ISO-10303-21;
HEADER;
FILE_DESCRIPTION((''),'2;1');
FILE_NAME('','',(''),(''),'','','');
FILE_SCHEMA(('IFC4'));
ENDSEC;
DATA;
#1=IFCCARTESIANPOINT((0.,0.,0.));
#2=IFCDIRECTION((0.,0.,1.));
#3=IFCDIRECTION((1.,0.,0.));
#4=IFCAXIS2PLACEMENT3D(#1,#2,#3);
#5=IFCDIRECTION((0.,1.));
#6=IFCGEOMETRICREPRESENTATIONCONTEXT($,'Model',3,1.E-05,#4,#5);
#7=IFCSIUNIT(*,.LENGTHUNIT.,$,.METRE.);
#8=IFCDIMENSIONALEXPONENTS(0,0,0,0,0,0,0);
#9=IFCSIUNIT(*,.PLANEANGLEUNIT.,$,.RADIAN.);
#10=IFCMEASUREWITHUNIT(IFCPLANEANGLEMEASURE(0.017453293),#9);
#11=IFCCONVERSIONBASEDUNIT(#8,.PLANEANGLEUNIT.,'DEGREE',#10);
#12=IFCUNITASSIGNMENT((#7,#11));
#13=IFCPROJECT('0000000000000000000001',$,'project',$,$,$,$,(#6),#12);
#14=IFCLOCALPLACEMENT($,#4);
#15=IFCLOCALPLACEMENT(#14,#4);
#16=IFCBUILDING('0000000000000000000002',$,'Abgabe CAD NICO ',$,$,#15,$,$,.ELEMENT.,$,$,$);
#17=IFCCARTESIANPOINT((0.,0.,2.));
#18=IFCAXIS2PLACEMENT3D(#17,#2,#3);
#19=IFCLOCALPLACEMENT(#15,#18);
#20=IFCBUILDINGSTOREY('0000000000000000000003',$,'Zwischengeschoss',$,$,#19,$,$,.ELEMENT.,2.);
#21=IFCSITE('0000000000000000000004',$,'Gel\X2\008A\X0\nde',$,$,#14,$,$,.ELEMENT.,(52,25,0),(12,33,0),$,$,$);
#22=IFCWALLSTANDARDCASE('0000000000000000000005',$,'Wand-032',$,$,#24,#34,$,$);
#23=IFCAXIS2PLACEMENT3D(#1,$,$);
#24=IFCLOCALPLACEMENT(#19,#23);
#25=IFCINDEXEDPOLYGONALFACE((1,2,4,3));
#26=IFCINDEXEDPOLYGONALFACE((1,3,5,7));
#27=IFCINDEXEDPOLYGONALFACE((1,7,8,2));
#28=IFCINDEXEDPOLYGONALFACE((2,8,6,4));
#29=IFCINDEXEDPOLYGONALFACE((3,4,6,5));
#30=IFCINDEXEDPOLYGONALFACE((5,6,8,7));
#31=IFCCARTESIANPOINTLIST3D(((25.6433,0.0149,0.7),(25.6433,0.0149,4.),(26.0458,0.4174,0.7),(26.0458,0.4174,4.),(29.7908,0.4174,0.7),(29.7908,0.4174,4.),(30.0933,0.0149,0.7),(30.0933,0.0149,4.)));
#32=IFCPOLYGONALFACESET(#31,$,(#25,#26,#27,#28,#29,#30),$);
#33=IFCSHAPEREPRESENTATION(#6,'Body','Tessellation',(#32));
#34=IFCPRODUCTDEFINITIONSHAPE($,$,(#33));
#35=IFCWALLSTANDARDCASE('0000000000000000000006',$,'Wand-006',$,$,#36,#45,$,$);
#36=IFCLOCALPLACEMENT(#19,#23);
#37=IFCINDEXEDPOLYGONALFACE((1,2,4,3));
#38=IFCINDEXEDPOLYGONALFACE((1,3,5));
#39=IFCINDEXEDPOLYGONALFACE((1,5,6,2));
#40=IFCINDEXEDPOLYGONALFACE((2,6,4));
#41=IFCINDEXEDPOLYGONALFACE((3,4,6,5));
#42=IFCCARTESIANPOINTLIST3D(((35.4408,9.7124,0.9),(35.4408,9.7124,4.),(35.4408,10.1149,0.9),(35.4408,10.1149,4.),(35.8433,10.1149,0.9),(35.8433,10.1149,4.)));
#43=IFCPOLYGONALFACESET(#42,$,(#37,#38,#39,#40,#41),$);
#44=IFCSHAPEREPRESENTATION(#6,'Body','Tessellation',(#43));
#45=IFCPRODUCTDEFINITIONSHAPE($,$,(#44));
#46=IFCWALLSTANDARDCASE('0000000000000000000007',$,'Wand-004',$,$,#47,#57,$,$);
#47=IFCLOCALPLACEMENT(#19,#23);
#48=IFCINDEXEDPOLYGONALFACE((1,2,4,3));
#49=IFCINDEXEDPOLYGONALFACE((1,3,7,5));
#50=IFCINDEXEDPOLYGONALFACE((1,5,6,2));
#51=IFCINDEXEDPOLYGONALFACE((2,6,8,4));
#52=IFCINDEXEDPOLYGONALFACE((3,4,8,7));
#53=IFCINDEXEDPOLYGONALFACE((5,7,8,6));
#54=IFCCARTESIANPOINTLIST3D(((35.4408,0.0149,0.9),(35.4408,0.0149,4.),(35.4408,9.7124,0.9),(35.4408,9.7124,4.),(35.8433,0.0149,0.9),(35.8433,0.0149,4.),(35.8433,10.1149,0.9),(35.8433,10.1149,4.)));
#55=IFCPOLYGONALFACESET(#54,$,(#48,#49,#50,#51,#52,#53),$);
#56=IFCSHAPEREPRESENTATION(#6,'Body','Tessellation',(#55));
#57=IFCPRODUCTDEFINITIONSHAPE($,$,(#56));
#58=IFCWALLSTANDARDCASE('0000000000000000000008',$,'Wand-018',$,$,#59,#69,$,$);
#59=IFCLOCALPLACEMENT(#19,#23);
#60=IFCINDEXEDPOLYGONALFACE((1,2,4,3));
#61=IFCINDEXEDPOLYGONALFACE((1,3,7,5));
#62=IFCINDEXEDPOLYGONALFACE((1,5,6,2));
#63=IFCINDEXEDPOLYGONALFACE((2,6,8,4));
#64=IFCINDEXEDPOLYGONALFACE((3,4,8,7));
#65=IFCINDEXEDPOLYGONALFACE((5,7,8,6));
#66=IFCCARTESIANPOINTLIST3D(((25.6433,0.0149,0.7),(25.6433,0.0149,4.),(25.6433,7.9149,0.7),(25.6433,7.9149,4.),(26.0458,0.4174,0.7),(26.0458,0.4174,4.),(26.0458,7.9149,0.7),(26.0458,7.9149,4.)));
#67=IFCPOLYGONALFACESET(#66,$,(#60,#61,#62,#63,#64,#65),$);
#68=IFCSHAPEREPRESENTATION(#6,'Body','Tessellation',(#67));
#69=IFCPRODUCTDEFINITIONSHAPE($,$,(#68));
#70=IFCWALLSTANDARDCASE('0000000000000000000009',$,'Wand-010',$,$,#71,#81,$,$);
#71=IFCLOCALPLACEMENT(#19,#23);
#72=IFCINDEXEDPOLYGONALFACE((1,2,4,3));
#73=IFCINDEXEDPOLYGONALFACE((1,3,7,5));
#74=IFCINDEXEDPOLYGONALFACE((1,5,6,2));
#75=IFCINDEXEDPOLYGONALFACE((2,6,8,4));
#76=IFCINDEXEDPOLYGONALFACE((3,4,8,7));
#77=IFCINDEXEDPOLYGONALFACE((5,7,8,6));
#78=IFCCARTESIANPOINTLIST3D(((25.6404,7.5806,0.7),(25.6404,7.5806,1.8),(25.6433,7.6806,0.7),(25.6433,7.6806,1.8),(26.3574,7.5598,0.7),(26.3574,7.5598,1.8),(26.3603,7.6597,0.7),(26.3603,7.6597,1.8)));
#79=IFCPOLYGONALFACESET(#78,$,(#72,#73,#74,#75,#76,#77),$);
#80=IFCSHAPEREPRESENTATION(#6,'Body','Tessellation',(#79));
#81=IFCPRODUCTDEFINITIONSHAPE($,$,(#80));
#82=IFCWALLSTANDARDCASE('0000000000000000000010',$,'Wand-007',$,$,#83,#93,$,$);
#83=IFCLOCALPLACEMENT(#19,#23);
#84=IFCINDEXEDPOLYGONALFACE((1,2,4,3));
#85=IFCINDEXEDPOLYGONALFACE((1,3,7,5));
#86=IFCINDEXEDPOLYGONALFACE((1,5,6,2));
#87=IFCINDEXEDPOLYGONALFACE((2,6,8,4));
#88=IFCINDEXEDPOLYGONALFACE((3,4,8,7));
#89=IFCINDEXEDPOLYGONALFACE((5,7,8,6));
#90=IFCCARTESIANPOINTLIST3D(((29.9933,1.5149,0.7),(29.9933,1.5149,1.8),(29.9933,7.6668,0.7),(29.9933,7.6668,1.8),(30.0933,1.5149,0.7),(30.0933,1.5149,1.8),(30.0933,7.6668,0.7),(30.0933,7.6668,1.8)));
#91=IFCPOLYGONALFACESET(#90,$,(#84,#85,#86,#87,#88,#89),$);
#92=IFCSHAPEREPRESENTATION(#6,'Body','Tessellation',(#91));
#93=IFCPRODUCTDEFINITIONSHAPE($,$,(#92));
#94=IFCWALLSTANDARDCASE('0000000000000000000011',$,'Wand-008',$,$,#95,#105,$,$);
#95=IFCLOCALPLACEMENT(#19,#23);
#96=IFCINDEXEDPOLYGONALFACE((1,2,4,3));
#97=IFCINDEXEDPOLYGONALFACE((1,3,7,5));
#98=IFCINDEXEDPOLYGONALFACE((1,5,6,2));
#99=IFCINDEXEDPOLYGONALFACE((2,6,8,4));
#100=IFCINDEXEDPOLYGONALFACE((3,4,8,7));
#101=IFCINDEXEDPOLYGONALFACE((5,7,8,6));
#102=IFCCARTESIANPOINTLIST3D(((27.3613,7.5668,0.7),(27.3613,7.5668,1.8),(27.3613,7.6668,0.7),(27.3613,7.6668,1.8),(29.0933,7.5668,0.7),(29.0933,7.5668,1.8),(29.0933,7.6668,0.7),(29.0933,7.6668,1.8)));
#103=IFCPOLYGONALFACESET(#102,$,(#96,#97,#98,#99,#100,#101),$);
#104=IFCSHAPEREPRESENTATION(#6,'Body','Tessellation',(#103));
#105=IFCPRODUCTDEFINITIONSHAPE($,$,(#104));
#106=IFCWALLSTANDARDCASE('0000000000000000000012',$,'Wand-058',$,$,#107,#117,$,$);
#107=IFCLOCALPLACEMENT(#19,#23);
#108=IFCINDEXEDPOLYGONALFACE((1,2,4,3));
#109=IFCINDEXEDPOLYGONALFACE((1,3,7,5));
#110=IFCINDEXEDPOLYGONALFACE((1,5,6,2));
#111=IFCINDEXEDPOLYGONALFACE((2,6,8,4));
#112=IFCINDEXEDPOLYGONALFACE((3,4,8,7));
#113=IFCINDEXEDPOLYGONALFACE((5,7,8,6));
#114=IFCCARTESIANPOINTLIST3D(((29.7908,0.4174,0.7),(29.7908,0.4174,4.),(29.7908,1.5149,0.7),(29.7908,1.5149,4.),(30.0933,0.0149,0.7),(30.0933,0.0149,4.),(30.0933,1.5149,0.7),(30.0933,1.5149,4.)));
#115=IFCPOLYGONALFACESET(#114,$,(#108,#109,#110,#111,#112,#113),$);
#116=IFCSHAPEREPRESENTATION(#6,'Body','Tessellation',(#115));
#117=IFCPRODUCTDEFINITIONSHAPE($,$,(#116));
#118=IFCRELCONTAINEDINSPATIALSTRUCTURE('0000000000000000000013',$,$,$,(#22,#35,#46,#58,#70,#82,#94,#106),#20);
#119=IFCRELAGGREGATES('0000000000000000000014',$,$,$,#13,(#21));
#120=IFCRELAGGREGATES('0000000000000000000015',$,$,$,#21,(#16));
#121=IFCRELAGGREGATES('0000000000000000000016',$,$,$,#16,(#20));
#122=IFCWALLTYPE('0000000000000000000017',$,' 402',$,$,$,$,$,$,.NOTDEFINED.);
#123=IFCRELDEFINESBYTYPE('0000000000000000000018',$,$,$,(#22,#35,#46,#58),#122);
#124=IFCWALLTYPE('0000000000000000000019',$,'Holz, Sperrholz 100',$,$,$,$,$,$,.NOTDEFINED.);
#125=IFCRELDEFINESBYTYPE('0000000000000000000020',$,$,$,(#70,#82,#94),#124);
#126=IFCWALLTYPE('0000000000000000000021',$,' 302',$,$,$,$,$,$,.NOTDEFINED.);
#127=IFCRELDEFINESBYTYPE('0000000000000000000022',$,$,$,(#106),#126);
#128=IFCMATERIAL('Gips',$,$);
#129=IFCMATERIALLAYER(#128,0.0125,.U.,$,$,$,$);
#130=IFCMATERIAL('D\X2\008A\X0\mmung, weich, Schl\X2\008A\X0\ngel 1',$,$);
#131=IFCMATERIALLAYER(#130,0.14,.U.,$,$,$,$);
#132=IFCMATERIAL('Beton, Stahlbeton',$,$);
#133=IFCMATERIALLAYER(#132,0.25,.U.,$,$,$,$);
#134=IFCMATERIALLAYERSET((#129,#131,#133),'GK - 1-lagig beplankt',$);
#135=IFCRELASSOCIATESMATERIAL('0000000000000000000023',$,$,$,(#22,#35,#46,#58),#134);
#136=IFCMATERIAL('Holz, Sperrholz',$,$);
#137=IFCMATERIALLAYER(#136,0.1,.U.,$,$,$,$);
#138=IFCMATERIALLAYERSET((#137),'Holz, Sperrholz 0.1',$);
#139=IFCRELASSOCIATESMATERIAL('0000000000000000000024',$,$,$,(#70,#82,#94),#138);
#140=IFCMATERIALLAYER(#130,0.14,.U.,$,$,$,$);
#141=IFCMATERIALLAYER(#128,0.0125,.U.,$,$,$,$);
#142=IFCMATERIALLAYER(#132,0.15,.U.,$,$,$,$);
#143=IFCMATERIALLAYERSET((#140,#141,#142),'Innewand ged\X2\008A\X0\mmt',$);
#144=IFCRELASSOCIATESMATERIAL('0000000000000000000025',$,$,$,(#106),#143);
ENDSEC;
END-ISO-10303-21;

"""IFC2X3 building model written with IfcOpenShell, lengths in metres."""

from ifc_helpers import new_model, entity, si_unit, converted_unit, direction, frame, origin_with_axes, place, context, project, spatial, polyline, outline, extrude, material, layer, layer_set, layer_usage, type_object, element, save


model = new_model("IFC2X3")

# Units and contexts
model_context = context("Model", 3, precision=1e-05, world=origin_with_axes(), true_north=direction((0.0, 1.0)))
ifc_project = project(units=[si_unit("LENGTHUNIT", "METRE"), converted_unit("PLANEANGLEUNIT", "DEGREE", entity("IfcPlaneAngleMeasure", 0.017453293), si_unit("PLANEANGLEUNIT", "RADIAN"), dimensions=[0, 0, 0, 0, 0, 0, 0])], contexts=[model_context])

# Site, building, storey
site_placement = place(None, origin_with_axes())
site = spatial("IfcSite", under=ifc_project, at=site_placement, Name="Gel\u008ande", CompositionType="ELEMENT", RefLatitude=(52, 25, 0), RefLongitude=(12, 33, 0))
building_placement = place(site_placement, origin_with_axes())
building = spatial("IfcBuilding", under=site, at=building_placement, Name="Abgabe CAD NICO ", CompositionType="ELEMENT")
storey_placement = place(building_placement, frame((0.0, 0.0, 2.0), z_axis=(0.0, 0.0, 1.0), x_axis=(1.0, 0.0, 0.0)))
storey = spatial("IfcBuildingStorey", under=building, at=storey_placement, Name="Zwischengeschoss", CompositionType="ELEMENT", Elevation=2.0)

# Shared definitions
ifc_material_1 = material(Name="Beton, Stahlbeton")

# Walls
ifc_material_2 = material(Name="Gips")
ifc_layer_1 = layer(ifc_material_2, 0.0125, ventilated="UNKNOWN")
ifc_material_3 = material(Name="D\u008ammung, weich, Schl\u008angel 1")
ifc_layer_2 = layer(ifc_material_3, 0.14, ventilated="UNKNOWN")
ifc_layer_3 = layer(ifc_material_1, 0.25, ventilated="UNKNOWN")
ifc_layer_set_1 = layer_set([ifc_layer_1, ifc_layer_2, ifc_layer_3], Name="GK - 1-lagig beplankt")
ifc_layer_usage_1 = layer_usage(ifc_layer_set_1, "AXIS2", "NEGATIVE", 0.0)
wall_type_1 = type_object("IfcWallType", Name=" 402", PredefinedType="NOTDEFINED")
wall_1_placement = place(storey_placement, frame((30.0933, 0.0149, 0.7), z_axis=(0.0, 0.0, 1.0), x_axis=(-1.0, 0.0, 0.0)))
element("IfcWallStandardCase", 1, at=wall_1_placement, inside=storey, type_object=wall_type_1, material=ifc_layer_usage_1, Name="Wand-032", context=model_context, shape_type="SweptSolid", body=[
    extrude(outline(polyline([(0.3025, -0.4025), (4.0475, -0.4025), (4.45, 0.0), (0.0, 0.0), (0.3025, -0.4025)])), origin_with_axes(), (0.0, 0.0, 1.0), 3.3),
])
ifc_layer_usage_2 = layer_usage(ifc_layer_set_1, "AXIS2", "NEGATIVE", 0.0)
wall_2_placement = place(storey_placement, frame((35.4408, 10.1149, 0.9), z_axis=(0.0, 0.0, 1.0), x_axis=(1.0, 0.0, 0.0)))
element("IfcWallStandardCase", 2, at=wall_2_placement, inside=storey, type_object=wall_type_1, material=ifc_layer_usage_2, Name="Wand-006", context=model_context, shape_type="SweptSolid", body=[
    extrude(outline(polyline([(0.0, -0.4025), (0.4025, 0.0), (0.0, 0.0), (0.0, -0.4025)])), origin_with_axes(), (0.0, 0.0, 1.0), 3.1),
])
ifc_layer_usage_3 = layer_usage(ifc_layer_set_1, "AXIS2", "NEGATIVE", 0.0)
wall_3_placement = place(storey_placement, frame((35.8433, 10.1149, 0.9), z_axis=(0.0, 0.0, 1.0), x_axis=(0.0, -1.0, 0.0)))
element("IfcWallStandardCase", 3, at=wall_3_placement, inside=storey, type_object=wall_type_1, material=ifc_layer_usage_3, Name="Wand-004", context=model_context, shape_type="SweptSolid", body=[
    extrude(outline(polyline([(0.4025, -0.4025), (10.1, -0.4025), (10.1, 0.0), (0.0, 0.0), (0.4025, -0.4025)])), origin_with_axes(), (0.0, 0.0, 1.0), 3.1),
])
ifc_layer_usage_4 = layer_usage(ifc_layer_set_1, "AXIS2", "NEGATIVE", 0.0)
wall_4_placement = place(storey_placement, frame((25.6433, 0.0149, 0.7), z_axis=(0.0, 0.0, 1.0), x_axis=(0.0, 1.0, 0.0)))
element("IfcWallStandardCase", 4, at=wall_4_placement, inside=storey, type_object=wall_type_1, material=ifc_layer_usage_4, Name="Wand-018", context=model_context, shape_type="SweptSolid", body=[
    extrude(outline(polyline([(0.4025, -0.4025), (7.9, -0.4025), (7.9, 0.0), (0.0, 0.0), (0.4025, -0.4025)])), origin_with_axes(), (0.0, 0.0, 1.0), 3.3),
])
ifc_material_4 = material(Name="Holz, Sperrholz")
ifc_layer_4 = layer(ifc_material_4, 0.1, ventilated="UNKNOWN")
ifc_layer_set_2 = layer_set([ifc_layer_4], Name="Holz, Sperrholz 0.1")
ifc_layer_usage_5 = layer_usage(ifc_layer_set_2, "AXIS2", "NEGATIVE", 0.0)
wall_type_2 = type_object("IfcWallType", Name="Holz, Sperrholz 100", PredefinedType="NOTDEFINED")
wall_5_placement = place(storey_placement, frame((25.6433, 7.6806, 0.7), z_axis=(0.0, 0.0, 1.0), x_axis=(0.999578, -0.029061, 0.0)))
element("IfcWallStandardCase", 5, at=wall_5_placement, inside=storey, type_object=wall_type_2, material=ifc_layer_usage_5, Name="Wand-010", context=model_context, shape_type="SweptSolid", body=[
    extrude(outline(polyline([(0.0, -0.1), (0.7174, -0.1), (0.7174, 0.0), (0.0, 0.0), (0.0, -0.1)])), origin_with_axes(), (0.0, 0.0, 1.0), 1.1),
])
ifc_layer_usage_6 = layer_usage(ifc_layer_set_2, "AXIS2", "NEGATIVE", 0.0)
wall_6_placement = place(storey_placement, frame((30.0933, 7.6668, 0.7), z_axis=(0.0, 0.0, 1.0), x_axis=(0.0, -1.0, 0.0)))
element("IfcWallStandardCase", 6, at=wall_6_placement, inside=storey, type_object=wall_type_2, material=ifc_layer_usage_6, Name="Wand-007", context=model_context, shape_type="SweptSolid", body=[
    extrude(outline(polyline([(0.0, -0.1), (6.152, -0.1), (6.152, 0.0), (0.0, 0.0), (0.0, -0.1)])), origin_with_axes(), (0.0, 0.0, 1.0), 1.1),
])
ifc_layer_usage_7 = layer_usage(ifc_layer_set_2, "AXIS2", "NEGATIVE", 0.0)
wall_7_placement = place(storey_placement, frame((27.3613, 7.6668, 0.7), z_axis=(0.0, 0.0, 1.0), x_axis=(1.0, 0.0, 0.0)))
element("IfcWallStandardCase", 7, at=wall_7_placement, inside=storey, type_object=wall_type_2, material=ifc_layer_usage_7, Name="Wand-008", context=model_context, shape_type="SweptSolid", body=[
    extrude(outline(polyline([(0.0, -0.1), (1.7319, -0.1), (1.7319, 0.0), (0.0, 0.0), (0.0, -0.1)])), origin_with_axes(), (0.0, 0.0, 1.0), 1.1),
])
ifc_layer_5 = layer(ifc_material_3, 0.14, ventilated="UNKNOWN")
ifc_layer_6 = layer(ifc_material_2, 0.0125, ventilated="UNKNOWN")
ifc_layer_7 = layer(ifc_material_1, 0.15, ventilated="UNKNOWN")
ifc_layer_set_3 = layer_set([ifc_layer_5, ifc_layer_6, ifc_layer_7], Name="Innewand ged\u008ammt")
ifc_layer_usage_8 = layer_usage(ifc_layer_set_3, "AXIS2", "NEGATIVE", 0.0)
wall_type_3 = type_object("IfcWallType", Name=" 302", PredefinedType="NOTDEFINED")
wall_8_placement = place(storey_placement, frame((30.0933, 1.5149, 0.7), z_axis=(0.0, 0.0, 1.0), x_axis=(0.0, -1.0, 0.0)))
element("IfcWallStandardCase", 8, at=wall_8_placement, inside=storey, type_object=wall_type_3, material=ifc_layer_usage_8, Name="Wand-058", context=model_context, shape_type="SweptSolid", body=[
    extrude(outline(polyline([(0.0, -0.3025), (1.0975, -0.3025), (1.5, 0.0), (0.0, 0.0), (0.0, -0.3025)])), origin_with_axes(), (0.0, 0.0, 1.0), 3.3),
])

save(model, "model.ifc")
